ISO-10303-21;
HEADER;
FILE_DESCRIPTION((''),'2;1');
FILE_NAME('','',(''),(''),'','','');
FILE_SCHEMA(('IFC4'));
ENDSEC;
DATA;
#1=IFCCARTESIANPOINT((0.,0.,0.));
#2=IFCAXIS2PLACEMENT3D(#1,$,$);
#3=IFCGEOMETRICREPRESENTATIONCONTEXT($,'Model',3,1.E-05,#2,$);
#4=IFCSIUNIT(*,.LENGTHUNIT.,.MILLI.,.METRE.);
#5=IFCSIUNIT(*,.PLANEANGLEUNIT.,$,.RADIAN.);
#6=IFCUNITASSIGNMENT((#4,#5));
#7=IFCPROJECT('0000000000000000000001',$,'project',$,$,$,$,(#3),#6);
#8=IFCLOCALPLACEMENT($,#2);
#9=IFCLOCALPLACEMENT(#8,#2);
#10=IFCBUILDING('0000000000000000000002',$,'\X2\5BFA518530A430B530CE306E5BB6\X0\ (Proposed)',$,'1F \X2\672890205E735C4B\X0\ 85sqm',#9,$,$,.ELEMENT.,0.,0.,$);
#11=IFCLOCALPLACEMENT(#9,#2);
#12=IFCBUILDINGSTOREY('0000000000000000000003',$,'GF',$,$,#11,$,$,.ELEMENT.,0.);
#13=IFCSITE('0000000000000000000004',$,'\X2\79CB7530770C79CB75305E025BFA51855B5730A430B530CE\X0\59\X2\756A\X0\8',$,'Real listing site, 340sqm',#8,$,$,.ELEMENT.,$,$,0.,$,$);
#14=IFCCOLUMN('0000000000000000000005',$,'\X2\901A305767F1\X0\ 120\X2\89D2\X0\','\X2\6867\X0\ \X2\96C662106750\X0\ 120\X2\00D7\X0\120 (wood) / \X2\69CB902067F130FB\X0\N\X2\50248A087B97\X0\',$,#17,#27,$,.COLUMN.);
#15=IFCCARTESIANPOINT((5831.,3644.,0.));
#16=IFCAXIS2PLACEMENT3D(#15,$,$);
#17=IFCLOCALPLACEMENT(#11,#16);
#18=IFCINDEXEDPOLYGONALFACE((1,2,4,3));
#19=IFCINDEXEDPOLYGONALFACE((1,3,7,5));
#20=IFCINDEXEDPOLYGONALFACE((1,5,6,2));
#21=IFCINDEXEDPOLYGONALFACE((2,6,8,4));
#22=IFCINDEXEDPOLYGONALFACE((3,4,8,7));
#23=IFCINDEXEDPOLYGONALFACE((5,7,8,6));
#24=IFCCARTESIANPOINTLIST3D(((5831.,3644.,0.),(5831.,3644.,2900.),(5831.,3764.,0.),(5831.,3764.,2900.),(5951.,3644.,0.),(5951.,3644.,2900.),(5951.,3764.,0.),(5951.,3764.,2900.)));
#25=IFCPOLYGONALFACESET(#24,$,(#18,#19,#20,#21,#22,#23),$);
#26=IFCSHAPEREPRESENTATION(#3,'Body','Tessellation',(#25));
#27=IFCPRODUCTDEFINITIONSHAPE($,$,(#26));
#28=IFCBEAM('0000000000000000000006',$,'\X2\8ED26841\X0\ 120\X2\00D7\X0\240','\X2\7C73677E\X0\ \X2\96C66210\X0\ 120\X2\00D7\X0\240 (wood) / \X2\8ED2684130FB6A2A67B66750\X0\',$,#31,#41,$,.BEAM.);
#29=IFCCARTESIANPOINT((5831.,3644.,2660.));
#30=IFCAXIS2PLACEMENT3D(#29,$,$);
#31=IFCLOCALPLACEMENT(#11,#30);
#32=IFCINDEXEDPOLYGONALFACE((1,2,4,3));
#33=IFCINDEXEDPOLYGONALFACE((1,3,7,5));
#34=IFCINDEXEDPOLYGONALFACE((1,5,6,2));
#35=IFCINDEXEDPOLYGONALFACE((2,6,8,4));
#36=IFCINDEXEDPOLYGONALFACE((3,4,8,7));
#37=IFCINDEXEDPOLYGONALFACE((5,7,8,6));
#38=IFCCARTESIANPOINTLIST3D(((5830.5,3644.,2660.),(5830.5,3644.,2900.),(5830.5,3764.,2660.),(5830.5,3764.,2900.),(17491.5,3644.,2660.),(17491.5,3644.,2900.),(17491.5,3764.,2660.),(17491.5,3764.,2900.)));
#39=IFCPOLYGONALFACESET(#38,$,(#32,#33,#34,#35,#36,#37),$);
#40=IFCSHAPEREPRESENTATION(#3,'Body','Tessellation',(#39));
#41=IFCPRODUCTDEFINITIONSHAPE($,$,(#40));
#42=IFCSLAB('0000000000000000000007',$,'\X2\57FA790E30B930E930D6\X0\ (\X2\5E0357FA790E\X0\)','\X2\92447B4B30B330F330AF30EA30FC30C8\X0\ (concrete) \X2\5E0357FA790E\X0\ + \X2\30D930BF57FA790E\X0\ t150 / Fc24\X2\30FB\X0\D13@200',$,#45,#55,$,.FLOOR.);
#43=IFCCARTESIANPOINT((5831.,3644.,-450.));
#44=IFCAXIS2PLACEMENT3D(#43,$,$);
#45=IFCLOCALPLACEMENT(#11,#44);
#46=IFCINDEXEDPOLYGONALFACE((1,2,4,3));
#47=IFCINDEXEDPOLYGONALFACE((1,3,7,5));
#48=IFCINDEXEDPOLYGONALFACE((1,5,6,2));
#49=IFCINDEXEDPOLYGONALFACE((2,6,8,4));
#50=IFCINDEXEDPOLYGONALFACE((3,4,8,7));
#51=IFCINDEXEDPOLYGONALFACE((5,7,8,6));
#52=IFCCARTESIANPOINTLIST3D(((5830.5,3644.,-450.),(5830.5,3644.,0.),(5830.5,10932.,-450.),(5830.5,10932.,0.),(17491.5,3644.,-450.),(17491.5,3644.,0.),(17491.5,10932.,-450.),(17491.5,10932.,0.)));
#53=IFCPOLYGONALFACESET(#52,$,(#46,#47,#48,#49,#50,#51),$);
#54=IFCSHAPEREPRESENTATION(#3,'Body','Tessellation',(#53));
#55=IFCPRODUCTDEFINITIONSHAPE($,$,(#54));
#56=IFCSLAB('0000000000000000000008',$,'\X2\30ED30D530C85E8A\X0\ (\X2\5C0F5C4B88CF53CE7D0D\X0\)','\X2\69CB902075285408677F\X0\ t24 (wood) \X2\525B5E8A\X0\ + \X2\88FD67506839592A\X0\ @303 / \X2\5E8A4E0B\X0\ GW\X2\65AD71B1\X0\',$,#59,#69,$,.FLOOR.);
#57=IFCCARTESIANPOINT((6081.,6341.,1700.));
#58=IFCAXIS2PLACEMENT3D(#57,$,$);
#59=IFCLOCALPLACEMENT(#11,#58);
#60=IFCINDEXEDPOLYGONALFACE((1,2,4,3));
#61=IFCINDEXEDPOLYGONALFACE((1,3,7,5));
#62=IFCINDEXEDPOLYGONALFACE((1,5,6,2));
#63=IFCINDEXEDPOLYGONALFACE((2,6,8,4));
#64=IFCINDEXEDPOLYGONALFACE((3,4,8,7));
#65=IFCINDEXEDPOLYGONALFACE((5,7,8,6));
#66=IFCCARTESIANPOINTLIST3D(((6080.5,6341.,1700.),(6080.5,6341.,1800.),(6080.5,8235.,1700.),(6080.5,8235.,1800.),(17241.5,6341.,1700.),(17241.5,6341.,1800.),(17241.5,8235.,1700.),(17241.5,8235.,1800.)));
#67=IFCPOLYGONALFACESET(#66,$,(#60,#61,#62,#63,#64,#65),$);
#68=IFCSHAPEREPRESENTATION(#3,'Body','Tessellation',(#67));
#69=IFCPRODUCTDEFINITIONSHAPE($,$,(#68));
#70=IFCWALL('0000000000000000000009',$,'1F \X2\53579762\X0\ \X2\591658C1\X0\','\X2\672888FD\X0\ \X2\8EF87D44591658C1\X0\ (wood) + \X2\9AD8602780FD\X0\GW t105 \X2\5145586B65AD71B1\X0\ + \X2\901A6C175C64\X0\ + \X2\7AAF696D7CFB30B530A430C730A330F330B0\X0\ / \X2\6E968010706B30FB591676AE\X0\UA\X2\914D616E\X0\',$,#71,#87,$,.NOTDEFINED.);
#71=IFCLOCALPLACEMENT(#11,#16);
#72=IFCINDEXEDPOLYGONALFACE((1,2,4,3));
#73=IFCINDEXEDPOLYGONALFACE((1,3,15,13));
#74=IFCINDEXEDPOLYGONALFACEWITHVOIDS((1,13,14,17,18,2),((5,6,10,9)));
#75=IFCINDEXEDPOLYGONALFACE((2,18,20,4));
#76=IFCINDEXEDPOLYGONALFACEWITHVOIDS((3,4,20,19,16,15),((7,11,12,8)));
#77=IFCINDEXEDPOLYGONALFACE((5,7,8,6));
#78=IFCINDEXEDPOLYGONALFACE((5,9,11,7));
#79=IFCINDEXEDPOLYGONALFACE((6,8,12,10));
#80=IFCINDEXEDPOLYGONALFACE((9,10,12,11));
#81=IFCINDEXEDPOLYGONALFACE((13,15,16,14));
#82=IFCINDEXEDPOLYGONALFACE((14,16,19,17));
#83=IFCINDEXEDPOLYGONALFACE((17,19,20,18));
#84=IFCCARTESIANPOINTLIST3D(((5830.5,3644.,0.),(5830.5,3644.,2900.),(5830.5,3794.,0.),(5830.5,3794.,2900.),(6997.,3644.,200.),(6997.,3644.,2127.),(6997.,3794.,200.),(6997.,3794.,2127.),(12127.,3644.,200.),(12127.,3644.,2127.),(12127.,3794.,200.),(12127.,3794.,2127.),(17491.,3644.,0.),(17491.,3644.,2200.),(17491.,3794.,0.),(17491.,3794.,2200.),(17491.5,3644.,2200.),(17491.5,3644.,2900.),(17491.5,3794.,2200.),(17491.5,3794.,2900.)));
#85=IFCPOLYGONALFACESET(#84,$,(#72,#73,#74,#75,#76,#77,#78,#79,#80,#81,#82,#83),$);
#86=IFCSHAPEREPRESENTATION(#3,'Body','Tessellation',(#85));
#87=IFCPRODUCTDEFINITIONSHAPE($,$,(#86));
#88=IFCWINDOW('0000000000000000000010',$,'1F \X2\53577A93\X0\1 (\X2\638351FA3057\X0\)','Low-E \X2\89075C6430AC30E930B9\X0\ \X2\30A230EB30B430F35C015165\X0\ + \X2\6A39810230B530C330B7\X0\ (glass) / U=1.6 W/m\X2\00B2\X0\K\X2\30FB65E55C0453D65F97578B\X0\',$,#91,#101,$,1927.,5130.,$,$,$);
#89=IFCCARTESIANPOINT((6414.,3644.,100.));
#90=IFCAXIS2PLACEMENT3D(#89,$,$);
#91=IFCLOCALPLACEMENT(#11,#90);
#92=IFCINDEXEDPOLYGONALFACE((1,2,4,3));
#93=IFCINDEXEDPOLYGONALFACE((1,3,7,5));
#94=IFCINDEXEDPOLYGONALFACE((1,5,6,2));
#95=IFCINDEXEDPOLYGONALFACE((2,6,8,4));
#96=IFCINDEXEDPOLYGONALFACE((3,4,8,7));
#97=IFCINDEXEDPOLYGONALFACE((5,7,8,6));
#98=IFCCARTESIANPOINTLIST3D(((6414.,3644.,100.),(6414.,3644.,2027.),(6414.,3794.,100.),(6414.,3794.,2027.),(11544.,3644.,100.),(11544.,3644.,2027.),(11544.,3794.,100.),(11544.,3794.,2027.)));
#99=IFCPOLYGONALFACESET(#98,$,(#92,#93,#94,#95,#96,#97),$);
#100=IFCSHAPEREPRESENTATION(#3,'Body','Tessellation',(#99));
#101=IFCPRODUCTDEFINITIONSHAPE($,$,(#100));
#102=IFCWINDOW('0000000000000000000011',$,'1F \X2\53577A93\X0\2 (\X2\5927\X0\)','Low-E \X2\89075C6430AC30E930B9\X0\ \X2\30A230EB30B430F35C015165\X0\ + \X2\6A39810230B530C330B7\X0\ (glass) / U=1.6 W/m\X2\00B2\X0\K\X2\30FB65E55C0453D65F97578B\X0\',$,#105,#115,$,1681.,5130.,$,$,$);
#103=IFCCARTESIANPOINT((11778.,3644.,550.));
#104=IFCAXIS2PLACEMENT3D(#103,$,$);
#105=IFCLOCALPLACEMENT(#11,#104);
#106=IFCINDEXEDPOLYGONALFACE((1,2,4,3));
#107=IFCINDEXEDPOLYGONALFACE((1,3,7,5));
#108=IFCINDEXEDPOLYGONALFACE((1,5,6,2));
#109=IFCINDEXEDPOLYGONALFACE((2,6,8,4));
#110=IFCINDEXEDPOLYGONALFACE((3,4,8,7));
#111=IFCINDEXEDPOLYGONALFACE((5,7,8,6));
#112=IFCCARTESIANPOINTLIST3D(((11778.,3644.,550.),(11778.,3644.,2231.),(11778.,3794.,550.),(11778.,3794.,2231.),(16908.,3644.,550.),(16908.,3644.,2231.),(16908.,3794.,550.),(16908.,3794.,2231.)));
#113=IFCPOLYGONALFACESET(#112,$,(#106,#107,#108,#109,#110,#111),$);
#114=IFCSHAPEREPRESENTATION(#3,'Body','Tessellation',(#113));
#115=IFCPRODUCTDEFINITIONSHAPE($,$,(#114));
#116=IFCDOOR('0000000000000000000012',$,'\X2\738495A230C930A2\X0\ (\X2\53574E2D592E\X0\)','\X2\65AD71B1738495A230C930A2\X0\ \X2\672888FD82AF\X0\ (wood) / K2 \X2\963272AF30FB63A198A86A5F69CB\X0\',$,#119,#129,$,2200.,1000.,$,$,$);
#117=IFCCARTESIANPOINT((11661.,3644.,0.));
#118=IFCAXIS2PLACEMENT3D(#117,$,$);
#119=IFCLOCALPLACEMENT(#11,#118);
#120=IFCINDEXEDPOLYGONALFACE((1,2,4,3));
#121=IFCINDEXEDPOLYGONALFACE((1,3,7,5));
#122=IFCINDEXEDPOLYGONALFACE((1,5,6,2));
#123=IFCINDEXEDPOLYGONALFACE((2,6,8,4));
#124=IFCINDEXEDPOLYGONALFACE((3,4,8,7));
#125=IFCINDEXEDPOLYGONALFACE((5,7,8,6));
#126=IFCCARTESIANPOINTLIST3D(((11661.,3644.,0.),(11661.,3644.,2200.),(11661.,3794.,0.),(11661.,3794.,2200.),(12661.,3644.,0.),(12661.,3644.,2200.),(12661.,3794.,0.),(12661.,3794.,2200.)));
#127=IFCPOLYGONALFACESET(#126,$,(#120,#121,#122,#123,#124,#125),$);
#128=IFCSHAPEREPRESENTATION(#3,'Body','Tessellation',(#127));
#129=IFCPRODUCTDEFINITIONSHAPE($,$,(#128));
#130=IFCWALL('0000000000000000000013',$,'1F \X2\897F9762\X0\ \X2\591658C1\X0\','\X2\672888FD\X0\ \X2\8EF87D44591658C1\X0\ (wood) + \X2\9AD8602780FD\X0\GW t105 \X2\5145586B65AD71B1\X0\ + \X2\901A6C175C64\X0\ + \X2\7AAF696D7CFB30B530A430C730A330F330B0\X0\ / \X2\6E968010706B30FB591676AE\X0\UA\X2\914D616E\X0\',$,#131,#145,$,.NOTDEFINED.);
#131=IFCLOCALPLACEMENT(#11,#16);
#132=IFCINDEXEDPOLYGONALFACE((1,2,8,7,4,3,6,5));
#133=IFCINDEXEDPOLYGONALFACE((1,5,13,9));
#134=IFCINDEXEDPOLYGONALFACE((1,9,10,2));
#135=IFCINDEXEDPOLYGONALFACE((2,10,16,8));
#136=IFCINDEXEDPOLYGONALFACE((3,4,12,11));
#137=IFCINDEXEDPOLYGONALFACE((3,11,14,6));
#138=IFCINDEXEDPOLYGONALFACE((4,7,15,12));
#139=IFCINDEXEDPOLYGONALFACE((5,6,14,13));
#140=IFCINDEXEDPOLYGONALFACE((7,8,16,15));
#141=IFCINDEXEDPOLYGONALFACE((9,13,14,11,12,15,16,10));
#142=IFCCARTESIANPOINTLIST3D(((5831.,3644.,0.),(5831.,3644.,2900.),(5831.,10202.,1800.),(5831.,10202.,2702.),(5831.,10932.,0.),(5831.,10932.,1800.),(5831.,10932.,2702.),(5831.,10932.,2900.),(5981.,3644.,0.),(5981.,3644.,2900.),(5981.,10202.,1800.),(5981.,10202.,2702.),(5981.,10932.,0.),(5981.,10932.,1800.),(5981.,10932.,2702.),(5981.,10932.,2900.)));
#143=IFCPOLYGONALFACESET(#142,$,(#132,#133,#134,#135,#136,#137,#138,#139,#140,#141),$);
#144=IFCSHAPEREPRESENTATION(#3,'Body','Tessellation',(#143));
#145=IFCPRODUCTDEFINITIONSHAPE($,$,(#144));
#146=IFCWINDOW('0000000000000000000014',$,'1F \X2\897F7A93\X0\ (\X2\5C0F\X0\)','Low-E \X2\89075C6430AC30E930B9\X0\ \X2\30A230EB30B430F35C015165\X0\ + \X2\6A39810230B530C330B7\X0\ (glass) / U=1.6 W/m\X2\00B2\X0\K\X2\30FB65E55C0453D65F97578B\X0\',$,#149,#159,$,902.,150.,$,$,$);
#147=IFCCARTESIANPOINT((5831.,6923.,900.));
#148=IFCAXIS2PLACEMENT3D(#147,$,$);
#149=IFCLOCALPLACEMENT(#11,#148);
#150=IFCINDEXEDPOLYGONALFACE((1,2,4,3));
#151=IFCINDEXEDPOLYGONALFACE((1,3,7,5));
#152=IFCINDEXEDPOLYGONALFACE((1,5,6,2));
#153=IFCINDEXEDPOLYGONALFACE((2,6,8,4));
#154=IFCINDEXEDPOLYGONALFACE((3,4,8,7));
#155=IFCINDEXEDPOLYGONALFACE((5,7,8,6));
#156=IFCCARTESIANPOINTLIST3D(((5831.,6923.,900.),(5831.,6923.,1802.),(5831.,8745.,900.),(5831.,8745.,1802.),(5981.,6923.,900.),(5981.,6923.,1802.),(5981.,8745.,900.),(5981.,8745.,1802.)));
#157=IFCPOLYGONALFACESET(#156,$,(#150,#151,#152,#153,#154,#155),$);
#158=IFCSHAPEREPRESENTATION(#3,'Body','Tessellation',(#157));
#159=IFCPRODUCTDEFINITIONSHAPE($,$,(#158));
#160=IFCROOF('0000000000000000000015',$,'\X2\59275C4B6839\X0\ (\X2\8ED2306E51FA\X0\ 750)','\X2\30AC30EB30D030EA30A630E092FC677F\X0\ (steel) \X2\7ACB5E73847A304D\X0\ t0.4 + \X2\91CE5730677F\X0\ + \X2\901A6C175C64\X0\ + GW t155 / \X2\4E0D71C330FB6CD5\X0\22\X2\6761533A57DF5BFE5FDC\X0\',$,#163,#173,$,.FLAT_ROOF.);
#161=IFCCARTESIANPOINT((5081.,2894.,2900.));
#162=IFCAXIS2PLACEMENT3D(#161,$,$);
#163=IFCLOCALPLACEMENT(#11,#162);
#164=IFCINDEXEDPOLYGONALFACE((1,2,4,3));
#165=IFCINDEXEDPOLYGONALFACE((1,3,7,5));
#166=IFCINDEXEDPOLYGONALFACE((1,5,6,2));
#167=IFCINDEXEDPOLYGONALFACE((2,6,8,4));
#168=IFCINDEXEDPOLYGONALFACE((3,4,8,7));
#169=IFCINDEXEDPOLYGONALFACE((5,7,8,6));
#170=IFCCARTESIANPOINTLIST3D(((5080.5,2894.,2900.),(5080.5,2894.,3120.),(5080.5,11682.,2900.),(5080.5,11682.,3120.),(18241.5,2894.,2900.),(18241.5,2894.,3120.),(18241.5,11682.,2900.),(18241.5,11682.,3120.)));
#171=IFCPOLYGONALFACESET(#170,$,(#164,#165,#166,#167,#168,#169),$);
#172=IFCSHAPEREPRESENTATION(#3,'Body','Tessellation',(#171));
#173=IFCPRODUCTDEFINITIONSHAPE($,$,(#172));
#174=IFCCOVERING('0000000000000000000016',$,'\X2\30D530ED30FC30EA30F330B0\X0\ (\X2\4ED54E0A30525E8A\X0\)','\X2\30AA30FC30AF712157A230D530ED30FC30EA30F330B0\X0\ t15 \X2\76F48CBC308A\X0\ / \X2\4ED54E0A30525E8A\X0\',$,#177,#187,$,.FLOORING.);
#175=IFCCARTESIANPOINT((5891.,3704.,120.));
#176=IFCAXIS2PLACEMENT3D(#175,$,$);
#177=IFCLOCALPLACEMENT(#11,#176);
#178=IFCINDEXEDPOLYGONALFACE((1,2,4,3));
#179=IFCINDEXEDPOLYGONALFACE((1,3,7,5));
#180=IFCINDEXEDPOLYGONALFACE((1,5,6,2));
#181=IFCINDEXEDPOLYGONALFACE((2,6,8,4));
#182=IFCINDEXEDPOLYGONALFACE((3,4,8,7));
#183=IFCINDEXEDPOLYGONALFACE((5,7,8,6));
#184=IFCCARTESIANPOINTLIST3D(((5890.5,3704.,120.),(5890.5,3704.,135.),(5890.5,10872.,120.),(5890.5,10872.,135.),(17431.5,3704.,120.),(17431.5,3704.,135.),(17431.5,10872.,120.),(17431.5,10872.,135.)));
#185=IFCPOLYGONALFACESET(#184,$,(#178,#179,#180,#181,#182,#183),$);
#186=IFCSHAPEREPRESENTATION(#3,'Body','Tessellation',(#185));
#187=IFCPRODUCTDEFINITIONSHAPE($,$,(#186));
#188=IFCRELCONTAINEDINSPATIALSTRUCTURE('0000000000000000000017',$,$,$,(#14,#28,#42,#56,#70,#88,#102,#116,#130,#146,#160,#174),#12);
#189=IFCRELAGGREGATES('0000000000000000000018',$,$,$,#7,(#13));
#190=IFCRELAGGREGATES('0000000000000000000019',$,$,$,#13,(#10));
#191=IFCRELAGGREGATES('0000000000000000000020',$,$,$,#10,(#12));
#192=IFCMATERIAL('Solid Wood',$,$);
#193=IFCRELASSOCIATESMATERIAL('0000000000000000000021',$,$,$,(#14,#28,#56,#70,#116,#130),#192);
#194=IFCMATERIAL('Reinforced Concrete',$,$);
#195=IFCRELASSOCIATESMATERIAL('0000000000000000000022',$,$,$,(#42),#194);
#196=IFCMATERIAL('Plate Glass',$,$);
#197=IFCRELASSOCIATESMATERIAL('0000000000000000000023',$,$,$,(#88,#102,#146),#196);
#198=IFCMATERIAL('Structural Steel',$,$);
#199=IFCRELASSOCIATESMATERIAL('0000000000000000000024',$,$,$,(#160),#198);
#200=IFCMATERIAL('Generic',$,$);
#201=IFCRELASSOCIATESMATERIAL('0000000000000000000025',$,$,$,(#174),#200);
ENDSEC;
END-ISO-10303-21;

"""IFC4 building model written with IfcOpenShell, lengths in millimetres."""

from ifc_helpers import new_model, si_unit, frame, frame_2d, origin, place, context, project, spatial, rectangle, extrude, material, element, fill, save


model = new_model("IFC4")

# Units and contexts
model_context = context("Model", 3, precision=1e-05, world=origin())
ifc_project = project(units=[si_unit("LENGTHUNIT", "METRE", prefix="MILLI"), si_unit("PLANEANGLEUNIT", "RADIAN")], contexts=[model_context])

# Site, building, storey
site_placement = place(None, origin())
site = spatial("IfcSite", under=ifc_project, at=site_placement, Name="秋田県秋田市寺内字イサノ59番8", ObjectType="Real listing site, 340sqm", CompositionType="ELEMENT", RefElevation=0.0)
building_placement = place(site_placement, origin())
building = spatial("IfcBuilding", under=site, at=building_placement, Name="寺内イサノの家 (Proposed)", ObjectType="1F 木造平屋 85sqm", CompositionType="ELEMENT", ElevationOfRefHeight=0.0, ElevationOfTerrain=0.0)
storey_placement = place(building_placement, origin())
storey = spatial("IfcBuildingStorey", under=building, at=storey_placement, Name="GF", CompositionType="ELEMENT", Elevation=0.0)

# Column
ifc_material_1 = material(Name="Solid Wood")
column_1_placement = place(storey_placement, frame((5831.0, 3644.0, 0.0)))
element("IfcColumn", 1, at=column_1_placement, inside=storey, material=ifc_material_1, Name="通し柱 120角", Description="桧 集成材 120×120 (wood) / 構造柱・N値計算", PredefinedType="COLUMN", context=model_context, shape_type="SweptSolid", body=[
    extrude(rectangle(XDim=120.0, YDim=120.0, at=frame_2d((60.0, 60.0))), frame((5831.0, 3644.0, 0.0)), (0.0, 0.0, 1.0), 2900.0),
])

# Beam
beam_1_placement = place(storey_placement, frame((5831.0, 3644.0, 2660.0)))
element("IfcBeam", 2, at=beam_1_placement, inside=storey, material=ifc_material_1, Name="軒桁 120×240", Description="米松 集成 120×240 (wood) / 軒桁・横架材", PredefinedType="BEAM", context=model_context, shape_type="SweptSolid", body=[
    extrude(rectangle(XDim=11661.0, YDim=120.0, at=frame_2d((5830.0, 60.0))), frame((5831.0, 3644.0, 2660.0)), (0.0, 0.0, 1.0), 240.0),
])

# Slabs
ifc_material_2 = material(Name="Reinforced Concrete")
slab_1_placement = place(storey_placement, frame((5831.0, 3644.0, -450.0)))
element("IfcSlab", 3, at=slab_1_placement, inside=storey, material=ifc_material_2, Name="基礎スラブ (布基礎)", Description="鉄筋コンクリート (concrete) 布基礎 + ベタ基礎 t150 / Fc24・D13@200", PredefinedType="FLOOR", context=model_context, shape_type="SweptSolid", body=[
    extrude(rectangle(XDim=11661.0, YDim=7288.0, at=frame_2d((5830.0, 3644.0))), frame((5831.0, 3644.0, -450.0)), (0.0, 0.0, 1.0), 450.0),
])
slab_2_placement = place(storey_placement, frame((6081.0, 6341.0, 1700.0)))
element("IfcSlab", 4, at=slab_2_placement, inside=storey, material=ifc_material_1, Name="ロフト床 (小屋裏収納)", Description="構造用合板 t24 (wood) 剛床 + 製材根太 @303 / 床下 GW断熱", PredefinedType="FLOOR", context=model_context, shape_type="SweptSolid", body=[
    extrude(rectangle(XDim=11161.0, YDim=1894.0, at=frame_2d((5580.0, 947.0))), frame((6081.0, 6341.0, 1700.0)), (0.0, 0.0, 1.0), 100.0),
])

# Wall, openings, windows, door
wall_1_placement = place(storey_placement, frame((5831.0, 3644.0, 0.0)))
wall_1 = element("IfcWall", 5, at=wall_1_placement, inside=storey, material=ifc_material_1, Name="1F 南面 外壁", Description="木製 軸組外壁 (wood) + 高性能GW t105 充填断熱 + 通気層 + 窯業系サイディング / 準耐火・外皮UA配慮", PredefinedType="NOTDEFINED", context=model_context, shape_type="SweptSolid", body=[
    extrude(rectangle(XDim=11661.0, YDim=150.0, at=frame_2d((5830.0, 75.0))), frame((5831.0, 3644.0, 0.0)), (0.0, 0.0, 1.0), 2900.0),
])
opening_1_placement = place(storey_placement, frame((6414.0, 3644.0, 100.0)))
opening_1 = element("IfcOpeningElement", 6, at=opening_1_placement, cuts=wall_1, PredefinedType="NOTDEFINED", context=model_context, shape_type="SweptSolid", body=[
    extrude(rectangle(XDim=5130.0, YDim=150.0, at=frame_2d((2565.0, 75.0))), frame((6414.0, 3644.0, 100.0)), (0.0, 0.0, 1.0), 1927.0),
])
opening_2_placement = place(storey_placement, frame((11778.0, 3644.0, 550.0)))
opening_2 = element("IfcOpeningElement", 7, at=opening_2_placement, cuts=wall_1, PredefinedType="NOTDEFINED", context=model_context, shape_type="SweptSolid", body=[
    extrude(rectangle(XDim=5130.0, YDim=150.0, at=frame_2d((2565.0, 75.0))), frame((11778.0, 3644.0, 550.0)), (0.0, 0.0, 1.0), 1681.0),
])
opening_3_placement = place(storey_placement, frame((11661.0, 3644.0, 0.0)))
opening_3 = element("IfcOpeningElement", 8, at=opening_3_placement, cuts=wall_1, PredefinedType="NOTDEFINED", context=model_context, shape_type="SweptSolid", body=[
    extrude(rectangle(XDim=1000.0, YDim=150.0, at=frame_2d((500.0, 75.0))), frame((11661.0, 3644.0, 0.0)), (0.0, 0.0, 1.0), 2200.0),
])
ifc_material_3 = material(Name="Plate Glass")
window_1_placement = place(storey_placement, frame((6414.0, 3644.0, 100.0)))
window_1 = element("IfcWindow", 9, at=window_1_placement, inside=storey, material=ifc_material_3, Name="1F 南窓1 (掃出し)", Description="Low-E 複層ガラス アルゴン封入 + 樹脂サッシ (glass) / U=1.6 W/m²K・日射取得型", OverallHeight=1927.0, OverallWidth=5130.0, context=model_context, shape_type="SweptSolid", body=[
    extrude(rectangle(XDim=5130.0, YDim=150.0, at=frame_2d((2565.0, 75.0))), frame((6414.0, 3644.0, 100.0)), (0.0, 0.0, 1.0), 1927.0),
])
fill(opening_1, window_1)
window_2_placement = place(storey_placement, frame((11778.0, 3644.0, 550.0)))
window_2 = element("IfcWindow", 10, at=window_2_placement, inside=storey, material=ifc_material_3, Name="1F 南窓2 (大)", Description="Low-E 複層ガラス アルゴン封入 + 樹脂サッシ (glass) / U=1.6 W/m²K・日射取得型", OverallHeight=1681.0, OverallWidth=5130.0, context=model_context, shape_type="SweptSolid", body=[
    extrude(rectangle(XDim=5130.0, YDim=150.0, at=frame_2d((2565.0, 75.0))), frame((11778.0, 3644.0, 550.0)), (0.0, 0.0, 1.0), 1681.0),
])
fill(opening_2, window_2)
door_placement = place(storey_placement, frame((11661.0, 3644.0, 0.0)))
door = element("IfcDoor", 11, at=door_placement, inside=storey, material=ifc_material_1, Name="玄関ドア (南中央)", Description="断熱玄関ドア 木製芯 (wood) / K2 防犯・採風機構", OverallHeight=2200.0, OverallWidth=1000.0, context=model_context, shape_type="SweptSolid", body=[
    extrude(rectangle(XDim=1000.0, YDim=150.0, at=frame_2d((500.0, 75.0))), frame((11661.0, 3644.0, 0.0)), (0.0, 0.0, 1.0), 2200.0),
])
fill(opening_3, door)

# Wall, opening, window
wall_2_placement = place(storey_placement, frame((5831.0, 3644.0, 0.0)))
wall_2 = element("IfcWall", 12, at=wall_2_placement, inside=storey, material=ifc_material_1, Name="1F 西面 外壁", Description="木製 軸組外壁 (wood) + 高性能GW t105 充填断熱 + 通気層 + 窯業系サイディング / 準耐火・外皮UA配慮", PredefinedType="NOTDEFINED", context=model_context, shape_type="SweptSolid", body=[
    extrude(rectangle(XDim=150.0, YDim=7288.0, at=frame_2d((75.0, 3644.0))), frame((5831.0, 3644.0, 0.0)), (0.0, 0.0, 1.0), 2900.0),
])
opening_4_placement = place(storey_placement, frame((5831.0, 6923.0, 900.0)))
opening_4 = element("IfcOpeningElement", 13, at=opening_4_placement, cuts=wall_2, PredefinedType="NOTDEFINED", context=model_context, shape_type="SweptSolid", body=[
    extrude(rectangle(XDim=150.0, YDim=1822.0, at=frame_2d((75.0, 911.0))), frame((5831.0, 6923.0, 900.0)), (0.0, 0.0, 1.0), 902.0),
])
window_3_placement = place(storey_placement, frame((5831.0, 6923.0, 900.0)))
window_3 = element("IfcWindow", 14, at=window_3_placement, inside=storey, material=ifc_material_3, Name="1F 西窓 (小)", Description="Low-E 複層ガラス アルゴン封入 + 樹脂サッシ (glass) / U=1.6 W/m²K・日射取得型", OverallHeight=902.0, OverallWidth=150.0, context=model_context, shape_type="SweptSolid", body=[
    extrude(rectangle(XDim=150.0, YDim=1822.0, at=frame_2d((75.0, 911.0))), frame((5831.0, 6923.0, 900.0)), (0.0, 0.0, 1.0), 902.0),
])
fill(opening_4, window_3)

# Roof
ifc_material_4 = material(Name="Structural Steel")
roof_placement = place(storey_placement, frame((5081.0, 2894.0, 2900.0)))
element("IfcRoof", 15, at=roof_placement, inside=storey, material=ifc_material_4, Name="大屋根 (軒の出 750)", Description="ガルバリウム鋼板 (steel) 立平葺き t0.4 + 野地板 + 通気層 + GW t155 / 不燃・法22条区域対応", PredefinedType="FLAT_ROOF", context=model_context, shape_type="SweptSolid", body=[
    extrude(rectangle(XDim=13161.0, YDim=8788.0, at=frame_2d((6580.0, 4394.0))), frame((5081.0, 2894.0, 2900.0)), (0.0, 0.0, 1.0), 220.0),
])

# Covering
ifc_material_5 = material(Name="Generic")
covering_1_placement = place(storey_placement, frame((5891.0, 3704.0, 120.0)))
element("IfcCovering", 16, at=covering_1_placement, inside=storey, material=ifc_material_5, Name="フローリング (仕上げ床)", Description="オーク無垢フローリング t15 直貼り / 仕上げ床", PredefinedType="FLOORING", context=model_context, shape_type="SweptSolid", body=[
    extrude(rectangle(XDim=11541.0, YDim=7168.0, at=frame_2d((5770.0, 3584.0))), frame((5891.0, 3704.0, 120.0)), (0.0, 0.0, 1.0), 15.0),
])

save(model, "model.ifc")
